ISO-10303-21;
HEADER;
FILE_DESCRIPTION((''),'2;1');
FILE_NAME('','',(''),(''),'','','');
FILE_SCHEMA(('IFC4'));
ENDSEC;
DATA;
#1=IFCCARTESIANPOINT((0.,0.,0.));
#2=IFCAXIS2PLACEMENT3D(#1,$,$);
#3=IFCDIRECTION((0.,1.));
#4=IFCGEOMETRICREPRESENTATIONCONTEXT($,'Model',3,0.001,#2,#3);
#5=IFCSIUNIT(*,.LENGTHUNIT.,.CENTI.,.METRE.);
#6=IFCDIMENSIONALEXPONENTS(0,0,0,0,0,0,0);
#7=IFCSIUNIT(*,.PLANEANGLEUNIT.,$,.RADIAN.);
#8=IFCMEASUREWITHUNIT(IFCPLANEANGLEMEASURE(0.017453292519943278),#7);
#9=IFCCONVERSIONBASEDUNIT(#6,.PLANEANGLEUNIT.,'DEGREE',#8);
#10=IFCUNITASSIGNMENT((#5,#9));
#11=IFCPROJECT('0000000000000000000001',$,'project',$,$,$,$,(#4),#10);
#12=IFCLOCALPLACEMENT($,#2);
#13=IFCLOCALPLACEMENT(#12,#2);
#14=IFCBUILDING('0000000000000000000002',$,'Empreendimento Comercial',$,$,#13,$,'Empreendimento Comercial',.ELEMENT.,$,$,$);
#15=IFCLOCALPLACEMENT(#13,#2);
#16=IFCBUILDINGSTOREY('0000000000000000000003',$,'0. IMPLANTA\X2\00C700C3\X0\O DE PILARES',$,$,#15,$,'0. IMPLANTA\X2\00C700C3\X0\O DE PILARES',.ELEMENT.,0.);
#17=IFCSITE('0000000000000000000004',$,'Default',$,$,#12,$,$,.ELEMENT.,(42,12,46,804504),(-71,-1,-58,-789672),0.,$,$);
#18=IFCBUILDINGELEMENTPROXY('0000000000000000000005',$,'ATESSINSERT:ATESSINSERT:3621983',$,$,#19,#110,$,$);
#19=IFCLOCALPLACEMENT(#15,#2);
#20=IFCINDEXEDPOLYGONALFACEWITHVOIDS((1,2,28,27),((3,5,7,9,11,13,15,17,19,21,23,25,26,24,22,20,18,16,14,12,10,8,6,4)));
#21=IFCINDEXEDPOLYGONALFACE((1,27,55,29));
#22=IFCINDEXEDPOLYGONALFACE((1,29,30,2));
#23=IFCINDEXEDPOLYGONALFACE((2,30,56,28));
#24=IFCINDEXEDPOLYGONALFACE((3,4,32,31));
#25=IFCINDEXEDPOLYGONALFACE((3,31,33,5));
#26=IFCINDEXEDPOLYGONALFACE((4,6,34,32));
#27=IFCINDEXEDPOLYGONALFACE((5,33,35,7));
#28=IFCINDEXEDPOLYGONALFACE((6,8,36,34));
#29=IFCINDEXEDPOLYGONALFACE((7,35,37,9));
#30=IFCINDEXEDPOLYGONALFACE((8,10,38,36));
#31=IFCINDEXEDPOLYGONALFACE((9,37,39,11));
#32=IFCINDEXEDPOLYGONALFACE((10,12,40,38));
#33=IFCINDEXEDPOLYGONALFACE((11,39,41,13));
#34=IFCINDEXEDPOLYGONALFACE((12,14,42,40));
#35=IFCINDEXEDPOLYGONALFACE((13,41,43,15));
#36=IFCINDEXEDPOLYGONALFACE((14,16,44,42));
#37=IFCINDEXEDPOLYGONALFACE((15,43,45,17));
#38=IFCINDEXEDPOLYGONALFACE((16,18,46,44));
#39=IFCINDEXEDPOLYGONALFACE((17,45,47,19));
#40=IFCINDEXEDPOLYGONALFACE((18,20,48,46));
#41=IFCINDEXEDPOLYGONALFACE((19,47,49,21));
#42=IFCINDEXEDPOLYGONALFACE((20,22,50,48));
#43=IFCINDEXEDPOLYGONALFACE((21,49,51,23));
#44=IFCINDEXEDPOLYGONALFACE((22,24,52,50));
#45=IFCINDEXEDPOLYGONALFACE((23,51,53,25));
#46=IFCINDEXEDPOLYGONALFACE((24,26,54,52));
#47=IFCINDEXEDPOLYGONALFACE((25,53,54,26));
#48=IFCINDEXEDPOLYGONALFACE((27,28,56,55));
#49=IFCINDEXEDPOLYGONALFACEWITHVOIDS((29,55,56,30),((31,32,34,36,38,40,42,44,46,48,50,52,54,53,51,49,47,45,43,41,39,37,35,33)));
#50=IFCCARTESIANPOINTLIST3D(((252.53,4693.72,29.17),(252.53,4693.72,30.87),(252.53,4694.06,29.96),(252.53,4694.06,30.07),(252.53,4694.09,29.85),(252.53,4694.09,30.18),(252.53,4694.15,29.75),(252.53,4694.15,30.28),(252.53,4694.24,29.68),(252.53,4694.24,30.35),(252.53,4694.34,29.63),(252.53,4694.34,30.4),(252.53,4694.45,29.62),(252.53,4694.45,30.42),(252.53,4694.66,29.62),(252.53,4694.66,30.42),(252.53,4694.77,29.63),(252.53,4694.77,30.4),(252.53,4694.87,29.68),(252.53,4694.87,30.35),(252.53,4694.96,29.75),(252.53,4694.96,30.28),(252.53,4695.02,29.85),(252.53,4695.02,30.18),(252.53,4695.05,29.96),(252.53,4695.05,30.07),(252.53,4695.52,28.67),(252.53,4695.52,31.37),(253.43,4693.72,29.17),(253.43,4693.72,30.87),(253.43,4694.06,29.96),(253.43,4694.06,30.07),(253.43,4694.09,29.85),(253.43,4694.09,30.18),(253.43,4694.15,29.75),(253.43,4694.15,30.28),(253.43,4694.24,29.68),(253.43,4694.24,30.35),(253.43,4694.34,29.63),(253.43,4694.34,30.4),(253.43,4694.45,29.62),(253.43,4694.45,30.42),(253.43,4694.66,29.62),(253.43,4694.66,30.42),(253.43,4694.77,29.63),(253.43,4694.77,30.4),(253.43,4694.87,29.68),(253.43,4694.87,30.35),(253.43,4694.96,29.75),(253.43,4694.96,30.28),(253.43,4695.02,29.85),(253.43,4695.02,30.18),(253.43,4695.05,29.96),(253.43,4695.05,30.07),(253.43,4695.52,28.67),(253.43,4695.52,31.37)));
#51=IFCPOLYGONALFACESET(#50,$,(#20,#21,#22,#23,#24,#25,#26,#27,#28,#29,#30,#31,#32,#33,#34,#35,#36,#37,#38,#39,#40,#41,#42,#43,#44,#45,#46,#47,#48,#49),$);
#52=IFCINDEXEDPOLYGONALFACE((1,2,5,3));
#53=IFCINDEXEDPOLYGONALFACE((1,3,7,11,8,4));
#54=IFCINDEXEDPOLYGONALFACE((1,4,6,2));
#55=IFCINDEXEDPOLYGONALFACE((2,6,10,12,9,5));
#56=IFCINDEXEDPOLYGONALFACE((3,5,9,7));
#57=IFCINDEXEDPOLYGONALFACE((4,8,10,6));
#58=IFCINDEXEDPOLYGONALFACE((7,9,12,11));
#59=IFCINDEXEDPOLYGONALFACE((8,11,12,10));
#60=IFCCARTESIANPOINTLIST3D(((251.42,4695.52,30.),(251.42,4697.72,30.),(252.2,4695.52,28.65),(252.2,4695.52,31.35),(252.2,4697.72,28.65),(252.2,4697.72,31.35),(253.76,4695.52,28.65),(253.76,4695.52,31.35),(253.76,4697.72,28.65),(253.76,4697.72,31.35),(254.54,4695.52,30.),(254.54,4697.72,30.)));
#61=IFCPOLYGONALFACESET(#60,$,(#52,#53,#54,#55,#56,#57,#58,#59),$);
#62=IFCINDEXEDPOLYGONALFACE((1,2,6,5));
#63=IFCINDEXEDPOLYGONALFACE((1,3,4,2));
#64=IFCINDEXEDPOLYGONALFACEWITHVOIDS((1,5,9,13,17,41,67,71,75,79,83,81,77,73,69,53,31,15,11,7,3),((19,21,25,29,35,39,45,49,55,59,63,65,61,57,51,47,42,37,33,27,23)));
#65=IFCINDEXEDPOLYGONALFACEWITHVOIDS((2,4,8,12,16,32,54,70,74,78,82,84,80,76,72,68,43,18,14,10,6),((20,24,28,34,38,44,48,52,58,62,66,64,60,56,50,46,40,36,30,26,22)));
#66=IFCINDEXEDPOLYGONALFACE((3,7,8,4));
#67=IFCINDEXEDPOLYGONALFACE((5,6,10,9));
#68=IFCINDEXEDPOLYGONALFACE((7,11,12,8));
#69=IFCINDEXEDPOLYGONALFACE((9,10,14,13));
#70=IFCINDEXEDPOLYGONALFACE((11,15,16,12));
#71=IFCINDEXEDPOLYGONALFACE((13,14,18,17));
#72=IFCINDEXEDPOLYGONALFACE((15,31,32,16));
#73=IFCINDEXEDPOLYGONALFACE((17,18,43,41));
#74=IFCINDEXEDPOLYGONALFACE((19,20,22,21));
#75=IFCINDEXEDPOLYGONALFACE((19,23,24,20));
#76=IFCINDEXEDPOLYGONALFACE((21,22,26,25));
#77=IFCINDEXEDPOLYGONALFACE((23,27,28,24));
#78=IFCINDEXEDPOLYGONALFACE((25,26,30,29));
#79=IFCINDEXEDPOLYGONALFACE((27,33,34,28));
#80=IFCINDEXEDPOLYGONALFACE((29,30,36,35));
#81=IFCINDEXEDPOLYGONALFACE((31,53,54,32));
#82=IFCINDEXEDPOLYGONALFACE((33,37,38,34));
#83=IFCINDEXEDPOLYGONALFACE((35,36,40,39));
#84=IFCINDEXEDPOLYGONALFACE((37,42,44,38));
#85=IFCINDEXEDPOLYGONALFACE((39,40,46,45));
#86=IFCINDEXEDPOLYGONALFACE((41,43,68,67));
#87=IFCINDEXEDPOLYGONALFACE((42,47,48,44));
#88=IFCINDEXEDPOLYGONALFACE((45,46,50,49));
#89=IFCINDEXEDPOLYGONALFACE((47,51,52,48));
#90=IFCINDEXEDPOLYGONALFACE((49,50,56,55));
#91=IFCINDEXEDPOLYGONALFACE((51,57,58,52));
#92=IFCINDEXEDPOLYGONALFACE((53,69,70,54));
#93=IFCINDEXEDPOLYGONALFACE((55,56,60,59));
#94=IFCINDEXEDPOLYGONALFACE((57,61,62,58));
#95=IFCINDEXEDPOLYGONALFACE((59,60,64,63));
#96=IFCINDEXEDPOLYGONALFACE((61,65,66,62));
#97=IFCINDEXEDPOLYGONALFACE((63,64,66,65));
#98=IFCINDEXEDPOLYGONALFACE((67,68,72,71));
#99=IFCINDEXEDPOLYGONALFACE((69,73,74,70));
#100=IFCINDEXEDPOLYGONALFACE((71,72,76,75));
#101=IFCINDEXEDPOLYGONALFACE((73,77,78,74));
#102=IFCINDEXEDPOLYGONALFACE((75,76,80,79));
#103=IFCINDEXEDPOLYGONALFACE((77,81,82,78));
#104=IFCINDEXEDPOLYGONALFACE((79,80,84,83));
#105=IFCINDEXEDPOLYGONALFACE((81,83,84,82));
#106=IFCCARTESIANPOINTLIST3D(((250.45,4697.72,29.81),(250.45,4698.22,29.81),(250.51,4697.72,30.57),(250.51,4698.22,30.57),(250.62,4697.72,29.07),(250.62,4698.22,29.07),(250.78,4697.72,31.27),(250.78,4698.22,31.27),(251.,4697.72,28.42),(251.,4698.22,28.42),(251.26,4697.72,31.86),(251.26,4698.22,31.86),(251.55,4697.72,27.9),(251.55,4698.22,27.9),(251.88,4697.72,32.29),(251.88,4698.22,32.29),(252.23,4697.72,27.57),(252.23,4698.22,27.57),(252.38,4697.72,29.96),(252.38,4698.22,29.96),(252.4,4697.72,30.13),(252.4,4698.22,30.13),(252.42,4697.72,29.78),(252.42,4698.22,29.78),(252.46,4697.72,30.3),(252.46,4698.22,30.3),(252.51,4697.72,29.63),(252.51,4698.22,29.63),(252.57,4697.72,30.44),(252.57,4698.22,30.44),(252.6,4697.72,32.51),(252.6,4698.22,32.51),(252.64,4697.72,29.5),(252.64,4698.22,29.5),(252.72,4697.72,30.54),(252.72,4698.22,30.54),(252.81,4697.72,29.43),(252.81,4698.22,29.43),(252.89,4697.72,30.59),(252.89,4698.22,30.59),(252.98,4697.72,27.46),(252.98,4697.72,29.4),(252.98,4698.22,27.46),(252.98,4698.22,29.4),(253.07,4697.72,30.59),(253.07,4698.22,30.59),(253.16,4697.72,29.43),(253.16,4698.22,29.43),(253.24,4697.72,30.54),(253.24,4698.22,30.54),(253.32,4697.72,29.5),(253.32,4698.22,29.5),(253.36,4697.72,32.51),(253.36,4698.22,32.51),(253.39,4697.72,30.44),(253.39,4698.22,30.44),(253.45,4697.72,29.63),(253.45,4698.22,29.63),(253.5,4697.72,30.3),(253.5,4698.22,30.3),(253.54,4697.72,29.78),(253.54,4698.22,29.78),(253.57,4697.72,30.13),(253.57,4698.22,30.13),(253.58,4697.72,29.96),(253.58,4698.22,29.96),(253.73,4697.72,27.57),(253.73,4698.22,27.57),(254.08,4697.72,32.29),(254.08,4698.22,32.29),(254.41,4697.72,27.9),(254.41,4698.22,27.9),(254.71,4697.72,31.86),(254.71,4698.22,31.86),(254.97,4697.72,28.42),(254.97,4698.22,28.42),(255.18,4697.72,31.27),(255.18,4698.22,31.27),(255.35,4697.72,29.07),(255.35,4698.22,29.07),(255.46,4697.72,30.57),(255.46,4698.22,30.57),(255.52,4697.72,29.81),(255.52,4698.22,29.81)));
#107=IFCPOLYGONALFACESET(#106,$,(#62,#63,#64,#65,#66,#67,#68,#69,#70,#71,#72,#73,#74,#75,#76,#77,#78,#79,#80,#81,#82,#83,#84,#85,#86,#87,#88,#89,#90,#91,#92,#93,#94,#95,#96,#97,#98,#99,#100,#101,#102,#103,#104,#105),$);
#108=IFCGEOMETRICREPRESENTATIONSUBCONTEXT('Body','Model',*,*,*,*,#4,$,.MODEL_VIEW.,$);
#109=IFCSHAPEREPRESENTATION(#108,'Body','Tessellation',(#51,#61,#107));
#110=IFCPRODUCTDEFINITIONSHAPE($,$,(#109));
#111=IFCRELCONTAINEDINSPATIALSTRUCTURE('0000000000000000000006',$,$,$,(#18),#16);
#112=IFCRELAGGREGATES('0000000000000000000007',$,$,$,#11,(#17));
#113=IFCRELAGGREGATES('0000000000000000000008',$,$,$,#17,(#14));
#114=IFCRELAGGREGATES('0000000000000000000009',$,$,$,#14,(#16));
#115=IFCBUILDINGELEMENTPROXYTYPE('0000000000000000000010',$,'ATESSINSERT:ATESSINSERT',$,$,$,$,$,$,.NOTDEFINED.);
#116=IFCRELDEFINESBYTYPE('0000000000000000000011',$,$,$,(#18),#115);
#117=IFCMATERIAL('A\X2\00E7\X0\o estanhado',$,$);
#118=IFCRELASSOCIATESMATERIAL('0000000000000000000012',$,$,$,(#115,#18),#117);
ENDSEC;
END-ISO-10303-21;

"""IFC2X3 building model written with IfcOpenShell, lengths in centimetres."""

from ifc_helpers import new_model, entity, si_unit, converted_unit, direction, frame, frame_2d, origin, place, context, subcontext, project, spatial, polyline, circle_curve, parameter, trimmed, segment, composite_curve, hollow_circle, outline, extrude, source, transform, mapped, material, type_object, type_shapes, element, save


model = new_model("IFC2X3")

# Units and contexts
model_context = context("Model", 3, precision=0.001, world=origin(), true_north=direction((0.0, 1.0)))
body_context = subcontext(model_context, "Body", "Model", "MODEL_VIEW")
ifc_project = project(units=[si_unit("LENGTHUNIT", "METRE", prefix="CENTI"), converted_unit("PLANEANGLEUNIT", "DEGREE", entity("IfcPlaneAngleMeasure", 0.017453292519943278), si_unit("PLANEANGLEUNIT", "RADIAN"), dimensions=[0, 0, 0, 0, 0, 0, 0])], contexts=[model_context])

# Site, building, storey
site_placement = place(None, origin())
site = spatial("IfcSite", under=ifc_project, at=site_placement, Name="Default", CompositionType="ELEMENT", RefLatitude=(42, 12, 46, 804504), RefLongitude=(-71, -1, -58, -789672), RefElevation=0.0)
building_placement = place(site_placement, origin())
building = spatial("IfcBuilding", under=site, at=building_placement, Name="Empreendimento Comercial", LongName="Empreendimento Comercial", CompositionType="ELEMENT")
storey_placement = place(building_placement, origin())
storey = spatial("IfcBuildingStorey", under=building, at=storey_placement, Name="0. IMPLANTAÇÃO DE PILARES", LongName="0. IMPLANTAÇÃO DE PILARES", CompositionType="ELEMENT", Elevation=0.0)

# Building element proxy
ifc_material_1 = material(Name="Aço estanhado")
building_element_proxy_type_1 = type_object("IfcBuildingElementProxyType", Name="ATESSINSERT:ATESSINSERT", PredefinedType="NOTDEFINED", material=ifc_material_1)
shared_shape_1 = source(origin(), body_context, "Body", "SweptSolid", [
    extrude(outline(polyline([(-1.35, -0.9), (1.35, -0.9), (0.85, 0.9), (-0.85, 0.9), (-1.35, -0.9)]), holes=[composite_curve([segment(trimmed(circle_curve(frame_2d((0.0, 0.17), x_axis=(1.0, 0.0)), 0.4), [parameter(0.0)], [parameter(180.0)], True, "PARAMETER"), False, "CONTINUOUS"), segment(polyline([(0.4, 0.17), (0.4, -0.03)]), True, "CONTINUOUS"), segment(trimmed(circle_curve(frame_2d((0.0, -0.03), x_axis=(1.0, 0.0)), 0.4), [parameter(180.0)], [parameter(0.0)], True, "PARAMETER"), False, "CONTINUOUS"), segment(polyline([(-0.4, -0.03), (-0.4, 0.17)]), True, "CONTINUOUS")], self_intersect=False)]), frame((-1.4, -0.45, 30.02), z_axis=(0.0, 1.0, 0.0), x_axis=(0.0, 0.0, 1.0)), (0.0, 0.0, 1.0), 0.9),
    extrude(outline(polyline([(-0.78, -1.35), (0.78, -1.35), (1.56, 0.0), (0.78, 1.35), (-0.78, 1.35), (-1.56, 0.0), (-0.78, -1.35)])), frame((-4.5, 0.0, 30.0), z_axis=(1.0, 0.0, 0.0), x_axis=(0.0, 0.5, 0.866025)), (0.0, 0.0, 1.0), 2.2),
    extrude(hollow_circle(Radius=2.54, WallThickness=1.94, at=frame_2d((0.0, 0.0), x_axis=(1.0, 0.0))), frame((-5.0, 0.0, 30.0), z_axis=(1.0, 0.0, 0.0), x_axis=(0.0, 0.0, -1.0)), (0.0, 0.0, 1.0), 0.5),
])
type_shapes(building_element_proxy_type_1, [shared_shape_1])
for number, where, z_axis, x_axis, name in (
    (1, (252.98, 4693.22, 0.0), (0.0, 0.0, 1.0), (0.0, -1.0, 0.0), "ATESSINSERT:ATESSINSERT:3621983"),
):
    element("IfcBuildingElementProxy", number, at=place(storey_placement, frame(where, z_axis=z_axis, x_axis=x_axis)), inside=storey, type_object=building_element_proxy_type_1, material=ifc_material_1, Name=name, context=body_context, shape_type="MappedRepresentation", body=[
        mapped(shared_shape_1, transform((0.0, 0.0, 0.0), scale=1.0)),
    ])

save(model, "model.ifc")
